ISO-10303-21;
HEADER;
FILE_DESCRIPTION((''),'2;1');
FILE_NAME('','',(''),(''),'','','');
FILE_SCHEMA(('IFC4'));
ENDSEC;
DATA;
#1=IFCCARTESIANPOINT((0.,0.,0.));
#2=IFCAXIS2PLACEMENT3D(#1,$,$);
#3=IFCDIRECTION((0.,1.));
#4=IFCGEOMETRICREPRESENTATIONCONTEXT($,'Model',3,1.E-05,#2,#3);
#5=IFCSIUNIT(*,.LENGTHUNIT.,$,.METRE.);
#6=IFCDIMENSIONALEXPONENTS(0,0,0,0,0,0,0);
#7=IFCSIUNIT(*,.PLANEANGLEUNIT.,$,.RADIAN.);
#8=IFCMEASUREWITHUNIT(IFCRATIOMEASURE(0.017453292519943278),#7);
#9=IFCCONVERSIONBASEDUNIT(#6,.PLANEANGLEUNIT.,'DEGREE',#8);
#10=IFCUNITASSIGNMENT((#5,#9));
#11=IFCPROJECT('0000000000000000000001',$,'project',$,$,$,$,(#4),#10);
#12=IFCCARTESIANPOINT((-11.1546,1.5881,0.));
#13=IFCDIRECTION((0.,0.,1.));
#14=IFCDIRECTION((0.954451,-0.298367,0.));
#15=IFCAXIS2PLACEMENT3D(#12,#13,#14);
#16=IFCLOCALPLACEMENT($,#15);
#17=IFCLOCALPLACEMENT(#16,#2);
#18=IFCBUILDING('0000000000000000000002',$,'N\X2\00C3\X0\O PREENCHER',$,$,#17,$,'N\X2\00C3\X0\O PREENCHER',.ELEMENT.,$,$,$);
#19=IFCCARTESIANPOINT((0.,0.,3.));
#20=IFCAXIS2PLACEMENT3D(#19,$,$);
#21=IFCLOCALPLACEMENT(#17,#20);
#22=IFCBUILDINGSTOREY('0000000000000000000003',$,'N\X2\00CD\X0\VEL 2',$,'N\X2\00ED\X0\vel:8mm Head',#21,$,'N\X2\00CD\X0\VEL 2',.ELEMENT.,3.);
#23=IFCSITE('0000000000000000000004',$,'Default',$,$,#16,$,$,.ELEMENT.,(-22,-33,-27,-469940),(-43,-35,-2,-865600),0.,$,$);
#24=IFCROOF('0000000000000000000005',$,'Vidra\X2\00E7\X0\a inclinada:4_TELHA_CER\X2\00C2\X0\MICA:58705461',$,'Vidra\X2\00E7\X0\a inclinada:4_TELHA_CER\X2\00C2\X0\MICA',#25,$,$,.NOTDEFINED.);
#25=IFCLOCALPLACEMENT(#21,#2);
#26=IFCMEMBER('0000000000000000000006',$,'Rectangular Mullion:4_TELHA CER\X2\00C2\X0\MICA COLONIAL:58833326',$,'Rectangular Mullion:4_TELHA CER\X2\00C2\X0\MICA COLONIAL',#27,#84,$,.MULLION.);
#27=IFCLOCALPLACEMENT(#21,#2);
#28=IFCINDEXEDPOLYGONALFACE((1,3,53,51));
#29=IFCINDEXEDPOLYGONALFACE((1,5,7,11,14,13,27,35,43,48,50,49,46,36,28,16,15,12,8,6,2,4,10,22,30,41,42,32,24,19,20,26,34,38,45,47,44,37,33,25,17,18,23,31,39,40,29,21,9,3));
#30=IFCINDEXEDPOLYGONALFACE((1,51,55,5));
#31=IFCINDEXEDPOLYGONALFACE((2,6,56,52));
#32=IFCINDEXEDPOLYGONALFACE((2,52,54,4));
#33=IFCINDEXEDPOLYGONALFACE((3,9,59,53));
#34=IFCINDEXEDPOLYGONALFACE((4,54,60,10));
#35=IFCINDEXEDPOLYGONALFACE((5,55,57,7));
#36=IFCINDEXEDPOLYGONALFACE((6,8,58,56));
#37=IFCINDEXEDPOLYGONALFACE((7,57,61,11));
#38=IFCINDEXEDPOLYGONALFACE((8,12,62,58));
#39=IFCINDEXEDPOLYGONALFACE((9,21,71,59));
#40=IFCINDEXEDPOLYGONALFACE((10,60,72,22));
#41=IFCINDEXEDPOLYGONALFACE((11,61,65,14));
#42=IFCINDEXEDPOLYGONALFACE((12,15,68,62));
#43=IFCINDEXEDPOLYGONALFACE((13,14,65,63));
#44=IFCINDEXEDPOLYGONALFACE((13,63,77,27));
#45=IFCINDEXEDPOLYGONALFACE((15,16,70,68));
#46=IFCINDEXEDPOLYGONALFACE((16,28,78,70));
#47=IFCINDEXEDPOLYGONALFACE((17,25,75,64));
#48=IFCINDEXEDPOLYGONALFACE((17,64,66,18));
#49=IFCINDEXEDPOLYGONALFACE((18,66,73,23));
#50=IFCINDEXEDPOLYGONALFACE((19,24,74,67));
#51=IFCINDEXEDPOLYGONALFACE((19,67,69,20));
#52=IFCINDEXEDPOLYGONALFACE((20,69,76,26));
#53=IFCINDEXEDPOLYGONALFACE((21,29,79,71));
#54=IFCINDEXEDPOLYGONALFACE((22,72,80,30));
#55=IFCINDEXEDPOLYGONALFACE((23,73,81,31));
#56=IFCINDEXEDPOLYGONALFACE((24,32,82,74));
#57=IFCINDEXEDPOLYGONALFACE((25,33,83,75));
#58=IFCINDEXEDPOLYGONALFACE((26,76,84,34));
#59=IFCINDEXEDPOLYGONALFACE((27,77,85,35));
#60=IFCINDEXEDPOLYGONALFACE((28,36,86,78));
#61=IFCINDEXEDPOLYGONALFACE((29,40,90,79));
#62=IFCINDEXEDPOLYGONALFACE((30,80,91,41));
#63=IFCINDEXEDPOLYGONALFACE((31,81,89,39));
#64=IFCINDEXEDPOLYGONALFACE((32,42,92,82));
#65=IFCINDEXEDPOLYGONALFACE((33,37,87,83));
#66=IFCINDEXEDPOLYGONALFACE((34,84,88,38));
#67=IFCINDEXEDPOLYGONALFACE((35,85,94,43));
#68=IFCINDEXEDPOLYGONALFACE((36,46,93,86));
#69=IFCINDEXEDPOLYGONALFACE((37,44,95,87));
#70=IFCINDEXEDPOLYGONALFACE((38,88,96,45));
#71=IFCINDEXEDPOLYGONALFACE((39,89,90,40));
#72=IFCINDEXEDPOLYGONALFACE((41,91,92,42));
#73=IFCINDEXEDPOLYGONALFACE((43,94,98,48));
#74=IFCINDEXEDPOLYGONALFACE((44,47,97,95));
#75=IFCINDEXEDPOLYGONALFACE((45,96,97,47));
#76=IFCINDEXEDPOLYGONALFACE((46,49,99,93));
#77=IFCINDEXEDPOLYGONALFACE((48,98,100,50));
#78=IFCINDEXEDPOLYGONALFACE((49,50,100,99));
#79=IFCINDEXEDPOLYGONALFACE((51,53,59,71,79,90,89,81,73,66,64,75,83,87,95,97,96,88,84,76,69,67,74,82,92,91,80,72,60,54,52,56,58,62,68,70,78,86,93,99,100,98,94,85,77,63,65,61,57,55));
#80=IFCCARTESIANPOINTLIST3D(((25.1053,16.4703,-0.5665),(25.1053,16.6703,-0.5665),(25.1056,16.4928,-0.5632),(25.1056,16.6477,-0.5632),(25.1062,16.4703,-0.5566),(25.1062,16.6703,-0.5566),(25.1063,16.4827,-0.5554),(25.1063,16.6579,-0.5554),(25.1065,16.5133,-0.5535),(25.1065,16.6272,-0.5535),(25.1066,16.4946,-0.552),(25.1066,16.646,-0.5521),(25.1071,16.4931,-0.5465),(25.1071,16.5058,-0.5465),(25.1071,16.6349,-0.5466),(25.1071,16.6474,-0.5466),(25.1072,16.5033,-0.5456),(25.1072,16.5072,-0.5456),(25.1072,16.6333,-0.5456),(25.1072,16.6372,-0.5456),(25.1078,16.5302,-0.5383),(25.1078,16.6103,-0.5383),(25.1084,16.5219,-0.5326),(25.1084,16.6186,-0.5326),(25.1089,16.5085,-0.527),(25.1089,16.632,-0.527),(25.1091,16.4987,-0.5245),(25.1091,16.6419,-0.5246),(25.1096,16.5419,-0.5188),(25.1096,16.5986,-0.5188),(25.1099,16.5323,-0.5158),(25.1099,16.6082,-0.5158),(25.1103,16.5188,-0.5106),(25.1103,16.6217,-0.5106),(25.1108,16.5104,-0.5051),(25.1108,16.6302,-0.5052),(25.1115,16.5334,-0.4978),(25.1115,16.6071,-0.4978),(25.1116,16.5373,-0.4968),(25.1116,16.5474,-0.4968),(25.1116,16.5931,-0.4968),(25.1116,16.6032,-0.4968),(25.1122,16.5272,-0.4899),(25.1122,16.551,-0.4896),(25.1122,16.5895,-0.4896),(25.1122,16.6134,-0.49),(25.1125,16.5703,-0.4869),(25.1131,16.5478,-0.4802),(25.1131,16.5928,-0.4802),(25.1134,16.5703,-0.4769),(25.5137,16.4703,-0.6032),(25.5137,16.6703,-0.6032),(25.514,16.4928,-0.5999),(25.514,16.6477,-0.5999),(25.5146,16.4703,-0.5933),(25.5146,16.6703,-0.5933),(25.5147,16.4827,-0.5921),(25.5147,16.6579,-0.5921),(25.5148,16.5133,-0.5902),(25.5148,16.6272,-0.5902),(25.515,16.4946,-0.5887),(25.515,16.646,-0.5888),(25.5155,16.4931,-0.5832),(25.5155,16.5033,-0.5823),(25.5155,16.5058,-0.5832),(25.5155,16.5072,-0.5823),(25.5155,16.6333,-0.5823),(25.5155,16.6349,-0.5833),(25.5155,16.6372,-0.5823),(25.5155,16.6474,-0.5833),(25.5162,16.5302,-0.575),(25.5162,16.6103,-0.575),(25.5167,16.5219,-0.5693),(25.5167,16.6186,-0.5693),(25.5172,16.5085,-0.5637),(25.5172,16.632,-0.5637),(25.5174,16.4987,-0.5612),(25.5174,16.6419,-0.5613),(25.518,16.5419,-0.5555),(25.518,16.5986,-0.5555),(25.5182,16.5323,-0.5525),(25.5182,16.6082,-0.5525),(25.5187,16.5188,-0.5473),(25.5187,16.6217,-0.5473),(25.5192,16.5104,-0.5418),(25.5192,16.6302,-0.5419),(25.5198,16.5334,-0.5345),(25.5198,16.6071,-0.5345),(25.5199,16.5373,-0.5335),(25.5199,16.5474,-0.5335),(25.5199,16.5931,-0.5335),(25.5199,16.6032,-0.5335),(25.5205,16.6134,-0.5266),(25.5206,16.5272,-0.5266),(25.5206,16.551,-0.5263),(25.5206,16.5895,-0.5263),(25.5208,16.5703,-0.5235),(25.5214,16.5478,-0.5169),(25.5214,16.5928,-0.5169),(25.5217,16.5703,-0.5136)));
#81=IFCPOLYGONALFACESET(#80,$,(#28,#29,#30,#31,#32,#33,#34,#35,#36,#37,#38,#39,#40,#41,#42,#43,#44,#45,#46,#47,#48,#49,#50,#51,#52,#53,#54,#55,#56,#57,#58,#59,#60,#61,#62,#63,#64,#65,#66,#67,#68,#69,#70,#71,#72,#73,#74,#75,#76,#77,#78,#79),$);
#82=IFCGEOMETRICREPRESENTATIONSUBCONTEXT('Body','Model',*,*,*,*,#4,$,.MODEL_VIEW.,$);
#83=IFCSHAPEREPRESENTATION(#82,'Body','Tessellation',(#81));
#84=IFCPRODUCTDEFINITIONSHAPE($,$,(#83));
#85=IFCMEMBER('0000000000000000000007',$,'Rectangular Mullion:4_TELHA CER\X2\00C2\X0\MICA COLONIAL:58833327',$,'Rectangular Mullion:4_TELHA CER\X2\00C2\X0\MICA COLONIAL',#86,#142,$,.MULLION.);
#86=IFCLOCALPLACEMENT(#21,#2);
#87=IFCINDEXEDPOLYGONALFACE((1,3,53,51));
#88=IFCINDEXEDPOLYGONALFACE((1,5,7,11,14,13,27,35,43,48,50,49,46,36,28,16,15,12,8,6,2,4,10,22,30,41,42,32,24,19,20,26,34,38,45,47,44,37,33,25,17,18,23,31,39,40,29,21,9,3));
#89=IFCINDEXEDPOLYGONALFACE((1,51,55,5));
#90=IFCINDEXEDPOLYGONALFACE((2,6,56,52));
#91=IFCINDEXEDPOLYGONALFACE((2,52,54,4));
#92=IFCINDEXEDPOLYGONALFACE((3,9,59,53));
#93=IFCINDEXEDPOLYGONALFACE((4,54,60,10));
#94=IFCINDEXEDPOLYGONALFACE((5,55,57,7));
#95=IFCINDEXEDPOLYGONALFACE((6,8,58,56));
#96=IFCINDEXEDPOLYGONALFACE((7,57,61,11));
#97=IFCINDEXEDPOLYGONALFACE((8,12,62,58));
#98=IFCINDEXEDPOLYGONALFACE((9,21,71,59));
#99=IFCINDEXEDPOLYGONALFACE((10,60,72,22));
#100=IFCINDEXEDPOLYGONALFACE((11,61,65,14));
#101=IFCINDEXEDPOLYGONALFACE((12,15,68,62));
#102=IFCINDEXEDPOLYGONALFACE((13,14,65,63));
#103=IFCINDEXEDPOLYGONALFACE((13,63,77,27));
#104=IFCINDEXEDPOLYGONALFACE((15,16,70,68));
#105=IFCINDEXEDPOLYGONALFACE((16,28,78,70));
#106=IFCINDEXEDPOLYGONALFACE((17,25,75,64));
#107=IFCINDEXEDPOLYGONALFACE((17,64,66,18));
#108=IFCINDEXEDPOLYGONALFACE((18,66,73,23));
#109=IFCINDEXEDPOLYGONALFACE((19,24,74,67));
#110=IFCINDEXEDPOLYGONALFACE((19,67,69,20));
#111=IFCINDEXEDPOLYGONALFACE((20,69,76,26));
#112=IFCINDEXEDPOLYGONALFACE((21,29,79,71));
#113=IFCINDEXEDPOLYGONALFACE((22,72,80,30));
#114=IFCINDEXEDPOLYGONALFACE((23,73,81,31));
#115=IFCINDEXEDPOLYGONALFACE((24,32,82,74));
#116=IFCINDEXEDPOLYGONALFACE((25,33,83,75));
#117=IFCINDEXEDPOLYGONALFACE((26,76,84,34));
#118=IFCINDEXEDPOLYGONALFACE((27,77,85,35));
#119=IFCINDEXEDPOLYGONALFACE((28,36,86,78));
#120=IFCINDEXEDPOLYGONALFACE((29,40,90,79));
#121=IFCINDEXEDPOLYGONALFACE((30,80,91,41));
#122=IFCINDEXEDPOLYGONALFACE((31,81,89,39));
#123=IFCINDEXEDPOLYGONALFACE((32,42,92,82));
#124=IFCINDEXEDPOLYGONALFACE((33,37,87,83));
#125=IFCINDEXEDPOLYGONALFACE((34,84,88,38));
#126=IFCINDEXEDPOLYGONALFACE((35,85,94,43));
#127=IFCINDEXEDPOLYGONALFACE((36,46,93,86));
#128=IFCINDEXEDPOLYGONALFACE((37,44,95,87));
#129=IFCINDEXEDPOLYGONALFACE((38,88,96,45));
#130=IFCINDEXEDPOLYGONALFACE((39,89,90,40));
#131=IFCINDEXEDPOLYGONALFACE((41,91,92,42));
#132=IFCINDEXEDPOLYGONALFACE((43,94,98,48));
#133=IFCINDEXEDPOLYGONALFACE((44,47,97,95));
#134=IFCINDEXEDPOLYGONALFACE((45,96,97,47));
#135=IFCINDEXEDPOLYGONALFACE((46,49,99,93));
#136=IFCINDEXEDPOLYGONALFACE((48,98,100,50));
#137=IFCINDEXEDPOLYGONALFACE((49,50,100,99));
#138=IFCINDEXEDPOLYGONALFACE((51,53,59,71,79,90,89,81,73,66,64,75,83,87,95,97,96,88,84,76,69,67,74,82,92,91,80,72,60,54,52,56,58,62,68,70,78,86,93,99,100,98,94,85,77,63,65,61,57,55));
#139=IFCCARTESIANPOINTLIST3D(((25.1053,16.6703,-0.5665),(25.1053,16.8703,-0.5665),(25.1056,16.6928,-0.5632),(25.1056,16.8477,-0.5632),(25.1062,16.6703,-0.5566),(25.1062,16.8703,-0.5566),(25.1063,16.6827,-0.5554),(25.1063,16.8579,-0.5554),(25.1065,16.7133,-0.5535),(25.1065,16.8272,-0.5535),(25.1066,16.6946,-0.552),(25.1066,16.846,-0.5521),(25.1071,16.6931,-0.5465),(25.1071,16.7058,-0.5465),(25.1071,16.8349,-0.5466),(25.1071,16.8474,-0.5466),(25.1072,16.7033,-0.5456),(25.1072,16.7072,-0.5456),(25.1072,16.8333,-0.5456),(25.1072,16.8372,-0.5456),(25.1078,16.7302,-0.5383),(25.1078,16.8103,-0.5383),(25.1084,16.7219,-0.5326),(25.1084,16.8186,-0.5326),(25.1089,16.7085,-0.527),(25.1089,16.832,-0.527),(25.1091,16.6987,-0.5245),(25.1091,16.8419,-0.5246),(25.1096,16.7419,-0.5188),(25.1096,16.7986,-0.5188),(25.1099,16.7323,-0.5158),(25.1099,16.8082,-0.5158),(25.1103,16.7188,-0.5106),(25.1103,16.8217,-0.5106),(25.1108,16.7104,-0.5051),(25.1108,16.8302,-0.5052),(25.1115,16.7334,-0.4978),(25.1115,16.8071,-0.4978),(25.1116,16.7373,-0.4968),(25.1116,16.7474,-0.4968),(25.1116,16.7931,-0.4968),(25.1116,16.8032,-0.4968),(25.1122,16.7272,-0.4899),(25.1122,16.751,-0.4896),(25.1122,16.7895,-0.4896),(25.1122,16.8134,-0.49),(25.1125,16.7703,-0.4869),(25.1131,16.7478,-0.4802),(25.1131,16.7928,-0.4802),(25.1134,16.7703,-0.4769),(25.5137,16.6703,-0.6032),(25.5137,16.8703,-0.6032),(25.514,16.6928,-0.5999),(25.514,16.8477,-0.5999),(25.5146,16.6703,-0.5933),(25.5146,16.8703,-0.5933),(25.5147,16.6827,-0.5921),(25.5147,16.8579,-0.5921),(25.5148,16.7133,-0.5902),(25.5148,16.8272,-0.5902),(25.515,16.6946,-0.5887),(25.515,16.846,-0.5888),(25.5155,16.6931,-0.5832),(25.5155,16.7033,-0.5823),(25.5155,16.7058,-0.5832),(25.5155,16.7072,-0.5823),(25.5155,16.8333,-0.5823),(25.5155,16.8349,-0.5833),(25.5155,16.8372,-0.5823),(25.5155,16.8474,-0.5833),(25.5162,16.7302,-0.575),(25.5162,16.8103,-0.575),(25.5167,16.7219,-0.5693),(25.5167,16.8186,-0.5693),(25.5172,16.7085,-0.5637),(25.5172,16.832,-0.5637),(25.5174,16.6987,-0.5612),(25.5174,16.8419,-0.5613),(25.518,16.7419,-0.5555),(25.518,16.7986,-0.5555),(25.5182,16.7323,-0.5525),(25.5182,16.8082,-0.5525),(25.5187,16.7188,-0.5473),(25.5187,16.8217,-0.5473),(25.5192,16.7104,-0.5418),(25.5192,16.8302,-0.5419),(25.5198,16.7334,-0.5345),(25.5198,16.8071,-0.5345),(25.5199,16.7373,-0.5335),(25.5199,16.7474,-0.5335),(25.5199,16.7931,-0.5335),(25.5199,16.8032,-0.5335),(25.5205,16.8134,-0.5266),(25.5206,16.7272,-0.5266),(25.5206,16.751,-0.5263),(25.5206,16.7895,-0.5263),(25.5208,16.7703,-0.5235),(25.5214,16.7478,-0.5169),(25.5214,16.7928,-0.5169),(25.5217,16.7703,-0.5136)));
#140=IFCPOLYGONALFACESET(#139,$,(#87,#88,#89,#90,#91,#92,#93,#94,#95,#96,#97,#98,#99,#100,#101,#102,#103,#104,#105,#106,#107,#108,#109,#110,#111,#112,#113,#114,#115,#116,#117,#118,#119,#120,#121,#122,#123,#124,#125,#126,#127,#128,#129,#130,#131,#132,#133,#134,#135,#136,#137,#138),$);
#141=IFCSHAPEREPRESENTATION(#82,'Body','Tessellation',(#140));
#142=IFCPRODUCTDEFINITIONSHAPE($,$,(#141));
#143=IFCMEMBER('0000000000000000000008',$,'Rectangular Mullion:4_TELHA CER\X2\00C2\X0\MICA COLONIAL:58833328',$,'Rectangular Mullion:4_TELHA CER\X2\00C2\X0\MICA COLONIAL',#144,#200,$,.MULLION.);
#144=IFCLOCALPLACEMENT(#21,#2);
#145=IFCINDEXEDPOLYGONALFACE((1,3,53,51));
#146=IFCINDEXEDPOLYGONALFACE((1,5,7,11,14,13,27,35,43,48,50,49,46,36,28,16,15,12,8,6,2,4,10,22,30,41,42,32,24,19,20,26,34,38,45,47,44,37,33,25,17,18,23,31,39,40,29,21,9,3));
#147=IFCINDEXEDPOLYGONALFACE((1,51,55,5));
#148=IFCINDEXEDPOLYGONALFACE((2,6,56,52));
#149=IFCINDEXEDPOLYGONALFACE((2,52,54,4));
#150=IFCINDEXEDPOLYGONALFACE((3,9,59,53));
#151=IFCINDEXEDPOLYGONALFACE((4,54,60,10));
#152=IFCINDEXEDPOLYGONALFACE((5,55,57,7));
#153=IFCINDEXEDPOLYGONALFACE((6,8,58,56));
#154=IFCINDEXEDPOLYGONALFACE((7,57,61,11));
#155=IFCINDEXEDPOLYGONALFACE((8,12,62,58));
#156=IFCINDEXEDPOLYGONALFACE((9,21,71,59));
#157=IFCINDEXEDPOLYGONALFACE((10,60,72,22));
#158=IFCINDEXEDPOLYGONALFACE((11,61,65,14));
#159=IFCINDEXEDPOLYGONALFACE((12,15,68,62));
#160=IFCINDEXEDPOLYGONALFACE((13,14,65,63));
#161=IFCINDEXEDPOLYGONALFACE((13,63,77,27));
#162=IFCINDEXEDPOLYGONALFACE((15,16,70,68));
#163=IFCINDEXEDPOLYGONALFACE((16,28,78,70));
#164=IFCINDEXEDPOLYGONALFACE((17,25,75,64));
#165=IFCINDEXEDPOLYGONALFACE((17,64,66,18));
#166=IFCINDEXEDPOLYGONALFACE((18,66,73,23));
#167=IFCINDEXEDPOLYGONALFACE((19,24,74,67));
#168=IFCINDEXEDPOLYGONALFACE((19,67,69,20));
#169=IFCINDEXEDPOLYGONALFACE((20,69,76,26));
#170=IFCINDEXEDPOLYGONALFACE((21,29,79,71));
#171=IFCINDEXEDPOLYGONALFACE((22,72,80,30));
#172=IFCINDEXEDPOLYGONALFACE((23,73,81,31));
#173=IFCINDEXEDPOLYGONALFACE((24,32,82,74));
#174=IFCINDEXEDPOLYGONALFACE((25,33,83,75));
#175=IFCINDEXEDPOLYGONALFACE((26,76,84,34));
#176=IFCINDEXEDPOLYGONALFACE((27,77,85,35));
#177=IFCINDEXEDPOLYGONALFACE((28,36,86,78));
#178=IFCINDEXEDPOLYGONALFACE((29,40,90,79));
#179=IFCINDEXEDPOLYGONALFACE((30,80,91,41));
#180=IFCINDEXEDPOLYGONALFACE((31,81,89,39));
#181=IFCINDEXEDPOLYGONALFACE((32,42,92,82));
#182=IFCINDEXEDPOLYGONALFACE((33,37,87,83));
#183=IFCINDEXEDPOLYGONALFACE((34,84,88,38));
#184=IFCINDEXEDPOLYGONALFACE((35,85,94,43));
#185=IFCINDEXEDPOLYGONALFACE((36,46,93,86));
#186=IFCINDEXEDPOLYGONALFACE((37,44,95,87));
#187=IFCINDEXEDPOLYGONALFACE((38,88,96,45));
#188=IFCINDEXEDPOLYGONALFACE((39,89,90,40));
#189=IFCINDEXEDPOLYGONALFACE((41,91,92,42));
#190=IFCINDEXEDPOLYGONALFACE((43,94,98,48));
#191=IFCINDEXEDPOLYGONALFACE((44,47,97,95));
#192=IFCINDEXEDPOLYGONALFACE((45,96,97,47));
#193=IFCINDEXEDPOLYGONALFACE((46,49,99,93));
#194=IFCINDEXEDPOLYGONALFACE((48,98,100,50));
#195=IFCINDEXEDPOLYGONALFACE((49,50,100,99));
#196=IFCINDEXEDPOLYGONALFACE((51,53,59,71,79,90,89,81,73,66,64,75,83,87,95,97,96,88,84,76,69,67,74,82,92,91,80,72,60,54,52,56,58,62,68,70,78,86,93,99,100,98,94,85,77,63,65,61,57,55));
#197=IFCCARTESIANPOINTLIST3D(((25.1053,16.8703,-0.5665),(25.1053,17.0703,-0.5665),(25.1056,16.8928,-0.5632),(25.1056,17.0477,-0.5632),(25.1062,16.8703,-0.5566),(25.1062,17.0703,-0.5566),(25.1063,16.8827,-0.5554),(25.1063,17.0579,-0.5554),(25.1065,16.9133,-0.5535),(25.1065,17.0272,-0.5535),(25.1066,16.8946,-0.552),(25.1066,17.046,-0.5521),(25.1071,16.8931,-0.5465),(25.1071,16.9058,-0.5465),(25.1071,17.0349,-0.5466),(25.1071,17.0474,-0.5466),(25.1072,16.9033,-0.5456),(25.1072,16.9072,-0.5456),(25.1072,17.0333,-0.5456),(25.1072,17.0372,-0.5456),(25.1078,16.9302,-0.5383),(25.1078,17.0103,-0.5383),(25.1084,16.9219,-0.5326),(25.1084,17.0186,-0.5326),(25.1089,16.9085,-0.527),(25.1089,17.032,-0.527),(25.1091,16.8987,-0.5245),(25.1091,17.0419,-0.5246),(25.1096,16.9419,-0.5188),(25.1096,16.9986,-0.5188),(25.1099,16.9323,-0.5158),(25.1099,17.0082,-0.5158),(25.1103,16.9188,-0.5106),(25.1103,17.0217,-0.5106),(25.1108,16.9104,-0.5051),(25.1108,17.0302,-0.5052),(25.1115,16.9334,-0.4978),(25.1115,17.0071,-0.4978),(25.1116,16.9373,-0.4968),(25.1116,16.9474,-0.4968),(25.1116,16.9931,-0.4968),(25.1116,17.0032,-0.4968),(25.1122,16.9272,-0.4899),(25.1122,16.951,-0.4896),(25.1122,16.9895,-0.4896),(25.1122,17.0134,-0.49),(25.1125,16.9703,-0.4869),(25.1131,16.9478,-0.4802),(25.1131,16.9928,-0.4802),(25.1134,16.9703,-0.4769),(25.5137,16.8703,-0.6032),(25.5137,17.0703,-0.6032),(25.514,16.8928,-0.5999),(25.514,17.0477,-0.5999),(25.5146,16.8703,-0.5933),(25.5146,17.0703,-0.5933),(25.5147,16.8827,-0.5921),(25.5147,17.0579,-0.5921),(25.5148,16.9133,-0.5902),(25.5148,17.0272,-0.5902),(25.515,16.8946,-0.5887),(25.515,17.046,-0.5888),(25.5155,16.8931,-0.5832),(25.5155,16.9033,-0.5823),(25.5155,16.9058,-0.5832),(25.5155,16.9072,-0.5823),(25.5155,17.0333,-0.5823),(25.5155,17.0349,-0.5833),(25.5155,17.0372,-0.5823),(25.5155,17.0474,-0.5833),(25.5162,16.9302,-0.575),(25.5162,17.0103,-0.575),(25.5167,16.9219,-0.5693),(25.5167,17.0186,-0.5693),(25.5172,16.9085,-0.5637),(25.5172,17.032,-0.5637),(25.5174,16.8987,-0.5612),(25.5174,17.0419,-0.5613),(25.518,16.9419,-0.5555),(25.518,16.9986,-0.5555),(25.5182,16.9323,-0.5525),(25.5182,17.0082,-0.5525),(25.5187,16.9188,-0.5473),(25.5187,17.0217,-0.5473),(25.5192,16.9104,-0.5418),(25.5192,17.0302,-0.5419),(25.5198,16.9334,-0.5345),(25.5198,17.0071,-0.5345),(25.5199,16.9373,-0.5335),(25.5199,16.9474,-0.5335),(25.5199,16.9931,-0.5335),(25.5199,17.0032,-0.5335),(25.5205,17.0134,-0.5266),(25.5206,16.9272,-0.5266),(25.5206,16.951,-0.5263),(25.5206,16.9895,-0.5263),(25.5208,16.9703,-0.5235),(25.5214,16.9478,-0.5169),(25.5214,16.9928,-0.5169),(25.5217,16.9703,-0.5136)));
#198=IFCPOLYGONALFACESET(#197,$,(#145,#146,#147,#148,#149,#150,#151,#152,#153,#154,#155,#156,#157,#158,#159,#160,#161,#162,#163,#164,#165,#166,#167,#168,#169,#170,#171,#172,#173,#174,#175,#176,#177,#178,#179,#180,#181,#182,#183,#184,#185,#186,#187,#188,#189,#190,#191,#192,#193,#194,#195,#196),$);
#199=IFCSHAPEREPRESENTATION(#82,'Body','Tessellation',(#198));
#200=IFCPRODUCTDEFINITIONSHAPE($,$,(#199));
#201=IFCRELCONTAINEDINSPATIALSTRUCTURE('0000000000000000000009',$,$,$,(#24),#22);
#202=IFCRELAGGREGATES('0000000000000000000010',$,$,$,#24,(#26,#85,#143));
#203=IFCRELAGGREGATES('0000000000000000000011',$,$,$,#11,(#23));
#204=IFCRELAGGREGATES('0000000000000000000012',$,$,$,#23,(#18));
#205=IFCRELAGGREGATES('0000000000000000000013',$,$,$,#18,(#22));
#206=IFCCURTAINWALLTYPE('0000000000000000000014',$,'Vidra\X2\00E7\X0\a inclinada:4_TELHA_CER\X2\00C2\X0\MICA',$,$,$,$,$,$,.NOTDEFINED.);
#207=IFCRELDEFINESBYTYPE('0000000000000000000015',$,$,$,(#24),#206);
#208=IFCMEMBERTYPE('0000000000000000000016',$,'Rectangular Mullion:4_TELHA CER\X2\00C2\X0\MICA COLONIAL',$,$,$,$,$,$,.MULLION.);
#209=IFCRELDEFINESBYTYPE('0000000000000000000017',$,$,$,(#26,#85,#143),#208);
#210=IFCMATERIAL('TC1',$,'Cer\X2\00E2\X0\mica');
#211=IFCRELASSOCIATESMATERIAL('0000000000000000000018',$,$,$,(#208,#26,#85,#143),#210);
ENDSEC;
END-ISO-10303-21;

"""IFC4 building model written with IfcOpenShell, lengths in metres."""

from ifc_helpers import new_model, entity, si_unit, converted_unit, direction, frame, origin, place, context, subcontext, project, spatial, line, arc, indexed_curve, outline, extrude, source, transform, mapped, material, type_object, type_shapes, element, aggregate, save


model = new_model("IFC4")

# Units and contexts
model_context = context("Model", 3, precision=1e-05, world=origin(), true_north=direction((0.0, 1.0)))
body_context = subcontext(model_context, "Body", "Model", "MODEL_VIEW")
ifc_project = project(units=[si_unit("LENGTHUNIT", "METRE"), converted_unit("PLANEANGLEUNIT", "DEGREE", entity("IfcRatioMeasure", 0.017453292519943278), si_unit("PLANEANGLEUNIT", "RADIAN"), dimensions=[0, 0, 0, 0, 0, 0, 0])], contexts=[model_context])

# Site, building, storey
site_placement = place(None, frame((-11.1546, 1.5881, 0.0), z_axis=(0.0, 0.0, 1.0), x_axis=(0.954451, -0.298367, 0.0)))
site = spatial("IfcSite", under=ifc_project, at=site_placement, Name="Default", CompositionType="ELEMENT", RefLatitude=(-22, -33, -27, -469940), RefLongitude=(-43, -35, -2, -865600), RefElevation=0.0)
building_placement = place(site_placement, origin())
building = spatial("IfcBuilding", under=site, at=building_placement, Name="NÃO PREENCHER", LongName="NÃO PREENCHER", CompositionType="ELEMENT")
storey_placement = place(building_placement, frame((0.0, 0.0, 3.0)))
storey = spatial("IfcBuildingStorey", under=building, at=storey_placement, Name="NÍVEL 2", ObjectType="Nível:8mm Head", LongName="NÍVEL 2", CompositionType="ELEMENT", Elevation=3.0)

# Roof, members
curtain_wall_type = type_object("IfcCurtainWallType", Name="Vidraça inclinada:4_TELHA_CERÂMICA", PredefinedType="NOTDEFINED")
roof_placement = place(storey_placement, frame((0.0, 0.0, -3.0)))
roof = element("IfcRoof", 1, at=roof_placement, inside=storey, type_object=curtain_wall_type, Name="Vidraça inclinada:4_TELHA_CERÂMICA:58705461", ObjectType="Vidraça inclinada:4_TELHA_CERÂMICA", PredefinedType="NOTDEFINED")
ifc_material = material(Name="TC1", Category="Cerâmica")
member_type = type_object("IfcMemberType", Name="Rectangular Mullion:4_TELHA CERÂMICA COLONIAL", PredefinedType="MULLION", material=ifc_material)
shared_shape = source(origin(), body_context, "Body", "SweptSolid", [
    extrude(outline(indexed_curve([(-0.029, -0.1), (-0.019, -0.1), (-0.0164, -0.0815), (-0.0089, -0.0645), (-0.0089, -0.0771), (0.061, 0.0), (-0.009, 0.0771), (-0.009, 0.0646), (-0.0165, 0.0816), (-0.019, 0.1), (-0.029, 0.1), (-0.0089, 0.0479), (0.041, 0.0229), (0.041, 0.0329), (0.0131, 0.0425), (-0.008, 0.0631), (-0.008, 0.067), (0.051, 0.0), (-0.008, -0.067), (-0.008, -0.0631), (0.0131, -0.0425), (0.041, -0.0329), (0.041, -0.0229), (-0.0089, -0.0479)], segments=[line(1, 2), arc(2, 3, 4), line(4, 5), arc(5, 6, 7), line(7, 8), arc(8, 9, 10), line(10, 11), arc(11, 12, 13), line(13, 14), arc(14, 15, 16), line(16, 17), arc(17, 18, 19), line(19, 20), arc(20, 21, 22), line(22, 23), arc(23, 24, 1)], self_intersect=False)), frame((0.0, -0.029, -0.41), z_axis=(0.0, 0.0, 1.0), x_axis=(0.0, -1.0, 0.0)), (0.0, 0.0, 1.0), 0.41),
])
type_shapes(member_type, [shared_shape])
member_1_placement = place(roof_placement, frame((25.1053, 16.5703, 2.4335), z_axis=(-0.99599, 0.0, 0.089469), x_axis=(0.0, 1.0, 0.0)))
member_1 = element("IfcMember", 2, at=member_1_placement, type_object=member_type, material=ifc_material, Name="Rectangular Mullion:4_TELHA CERÂMICA COLONIAL:58833326", ObjectType="Rectangular Mullion:4_TELHA CERÂMICA COLONIAL", PredefinedType="MULLION", context=body_context, shape_type="MappedRepresentation", body=[
    mapped(shared_shape, transform((0.0, 0.0, 0.0), scale=1.0)),
])
member_2_placement = place(roof_placement, frame((25.1053, 16.7703, 2.4335), z_axis=(-0.99599, 0.0, 0.089469), x_axis=(0.0, 1.0, 0.0)))
member_2 = element("IfcMember", 3, at=member_2_placement, type_object=member_type, material=ifc_material, Name="Rectangular Mullion:4_TELHA CERÂMICA COLONIAL:58833327", ObjectType="Rectangular Mullion:4_TELHA CERÂMICA COLONIAL", PredefinedType="MULLION", context=body_context, shape_type="MappedRepresentation", body=[
    mapped(shared_shape, transform((0.0, 0.0, 0.0), scale=1.0)),
])
member_3_placement = place(roof_placement, frame((25.1053, 16.9703, 2.4335), z_axis=(-0.99599, 0.0, 0.089469), x_axis=(0.0, 1.0, 0.0)))
member_3 = element("IfcMember", 4, at=member_3_placement, type_object=member_type, material=ifc_material, Name="Rectangular Mullion:4_TELHA CERÂMICA COLONIAL:58833328", ObjectType="Rectangular Mullion:4_TELHA CERÂMICA COLONIAL", PredefinedType="MULLION", context=body_context, shape_type="MappedRepresentation", body=[
    mapped(shared_shape, transform((0.0, 0.0, 0.0), scale=1.0)),
])
aggregate(roof, [member_1, member_2, member_3])

save(model, "model.ifc")
